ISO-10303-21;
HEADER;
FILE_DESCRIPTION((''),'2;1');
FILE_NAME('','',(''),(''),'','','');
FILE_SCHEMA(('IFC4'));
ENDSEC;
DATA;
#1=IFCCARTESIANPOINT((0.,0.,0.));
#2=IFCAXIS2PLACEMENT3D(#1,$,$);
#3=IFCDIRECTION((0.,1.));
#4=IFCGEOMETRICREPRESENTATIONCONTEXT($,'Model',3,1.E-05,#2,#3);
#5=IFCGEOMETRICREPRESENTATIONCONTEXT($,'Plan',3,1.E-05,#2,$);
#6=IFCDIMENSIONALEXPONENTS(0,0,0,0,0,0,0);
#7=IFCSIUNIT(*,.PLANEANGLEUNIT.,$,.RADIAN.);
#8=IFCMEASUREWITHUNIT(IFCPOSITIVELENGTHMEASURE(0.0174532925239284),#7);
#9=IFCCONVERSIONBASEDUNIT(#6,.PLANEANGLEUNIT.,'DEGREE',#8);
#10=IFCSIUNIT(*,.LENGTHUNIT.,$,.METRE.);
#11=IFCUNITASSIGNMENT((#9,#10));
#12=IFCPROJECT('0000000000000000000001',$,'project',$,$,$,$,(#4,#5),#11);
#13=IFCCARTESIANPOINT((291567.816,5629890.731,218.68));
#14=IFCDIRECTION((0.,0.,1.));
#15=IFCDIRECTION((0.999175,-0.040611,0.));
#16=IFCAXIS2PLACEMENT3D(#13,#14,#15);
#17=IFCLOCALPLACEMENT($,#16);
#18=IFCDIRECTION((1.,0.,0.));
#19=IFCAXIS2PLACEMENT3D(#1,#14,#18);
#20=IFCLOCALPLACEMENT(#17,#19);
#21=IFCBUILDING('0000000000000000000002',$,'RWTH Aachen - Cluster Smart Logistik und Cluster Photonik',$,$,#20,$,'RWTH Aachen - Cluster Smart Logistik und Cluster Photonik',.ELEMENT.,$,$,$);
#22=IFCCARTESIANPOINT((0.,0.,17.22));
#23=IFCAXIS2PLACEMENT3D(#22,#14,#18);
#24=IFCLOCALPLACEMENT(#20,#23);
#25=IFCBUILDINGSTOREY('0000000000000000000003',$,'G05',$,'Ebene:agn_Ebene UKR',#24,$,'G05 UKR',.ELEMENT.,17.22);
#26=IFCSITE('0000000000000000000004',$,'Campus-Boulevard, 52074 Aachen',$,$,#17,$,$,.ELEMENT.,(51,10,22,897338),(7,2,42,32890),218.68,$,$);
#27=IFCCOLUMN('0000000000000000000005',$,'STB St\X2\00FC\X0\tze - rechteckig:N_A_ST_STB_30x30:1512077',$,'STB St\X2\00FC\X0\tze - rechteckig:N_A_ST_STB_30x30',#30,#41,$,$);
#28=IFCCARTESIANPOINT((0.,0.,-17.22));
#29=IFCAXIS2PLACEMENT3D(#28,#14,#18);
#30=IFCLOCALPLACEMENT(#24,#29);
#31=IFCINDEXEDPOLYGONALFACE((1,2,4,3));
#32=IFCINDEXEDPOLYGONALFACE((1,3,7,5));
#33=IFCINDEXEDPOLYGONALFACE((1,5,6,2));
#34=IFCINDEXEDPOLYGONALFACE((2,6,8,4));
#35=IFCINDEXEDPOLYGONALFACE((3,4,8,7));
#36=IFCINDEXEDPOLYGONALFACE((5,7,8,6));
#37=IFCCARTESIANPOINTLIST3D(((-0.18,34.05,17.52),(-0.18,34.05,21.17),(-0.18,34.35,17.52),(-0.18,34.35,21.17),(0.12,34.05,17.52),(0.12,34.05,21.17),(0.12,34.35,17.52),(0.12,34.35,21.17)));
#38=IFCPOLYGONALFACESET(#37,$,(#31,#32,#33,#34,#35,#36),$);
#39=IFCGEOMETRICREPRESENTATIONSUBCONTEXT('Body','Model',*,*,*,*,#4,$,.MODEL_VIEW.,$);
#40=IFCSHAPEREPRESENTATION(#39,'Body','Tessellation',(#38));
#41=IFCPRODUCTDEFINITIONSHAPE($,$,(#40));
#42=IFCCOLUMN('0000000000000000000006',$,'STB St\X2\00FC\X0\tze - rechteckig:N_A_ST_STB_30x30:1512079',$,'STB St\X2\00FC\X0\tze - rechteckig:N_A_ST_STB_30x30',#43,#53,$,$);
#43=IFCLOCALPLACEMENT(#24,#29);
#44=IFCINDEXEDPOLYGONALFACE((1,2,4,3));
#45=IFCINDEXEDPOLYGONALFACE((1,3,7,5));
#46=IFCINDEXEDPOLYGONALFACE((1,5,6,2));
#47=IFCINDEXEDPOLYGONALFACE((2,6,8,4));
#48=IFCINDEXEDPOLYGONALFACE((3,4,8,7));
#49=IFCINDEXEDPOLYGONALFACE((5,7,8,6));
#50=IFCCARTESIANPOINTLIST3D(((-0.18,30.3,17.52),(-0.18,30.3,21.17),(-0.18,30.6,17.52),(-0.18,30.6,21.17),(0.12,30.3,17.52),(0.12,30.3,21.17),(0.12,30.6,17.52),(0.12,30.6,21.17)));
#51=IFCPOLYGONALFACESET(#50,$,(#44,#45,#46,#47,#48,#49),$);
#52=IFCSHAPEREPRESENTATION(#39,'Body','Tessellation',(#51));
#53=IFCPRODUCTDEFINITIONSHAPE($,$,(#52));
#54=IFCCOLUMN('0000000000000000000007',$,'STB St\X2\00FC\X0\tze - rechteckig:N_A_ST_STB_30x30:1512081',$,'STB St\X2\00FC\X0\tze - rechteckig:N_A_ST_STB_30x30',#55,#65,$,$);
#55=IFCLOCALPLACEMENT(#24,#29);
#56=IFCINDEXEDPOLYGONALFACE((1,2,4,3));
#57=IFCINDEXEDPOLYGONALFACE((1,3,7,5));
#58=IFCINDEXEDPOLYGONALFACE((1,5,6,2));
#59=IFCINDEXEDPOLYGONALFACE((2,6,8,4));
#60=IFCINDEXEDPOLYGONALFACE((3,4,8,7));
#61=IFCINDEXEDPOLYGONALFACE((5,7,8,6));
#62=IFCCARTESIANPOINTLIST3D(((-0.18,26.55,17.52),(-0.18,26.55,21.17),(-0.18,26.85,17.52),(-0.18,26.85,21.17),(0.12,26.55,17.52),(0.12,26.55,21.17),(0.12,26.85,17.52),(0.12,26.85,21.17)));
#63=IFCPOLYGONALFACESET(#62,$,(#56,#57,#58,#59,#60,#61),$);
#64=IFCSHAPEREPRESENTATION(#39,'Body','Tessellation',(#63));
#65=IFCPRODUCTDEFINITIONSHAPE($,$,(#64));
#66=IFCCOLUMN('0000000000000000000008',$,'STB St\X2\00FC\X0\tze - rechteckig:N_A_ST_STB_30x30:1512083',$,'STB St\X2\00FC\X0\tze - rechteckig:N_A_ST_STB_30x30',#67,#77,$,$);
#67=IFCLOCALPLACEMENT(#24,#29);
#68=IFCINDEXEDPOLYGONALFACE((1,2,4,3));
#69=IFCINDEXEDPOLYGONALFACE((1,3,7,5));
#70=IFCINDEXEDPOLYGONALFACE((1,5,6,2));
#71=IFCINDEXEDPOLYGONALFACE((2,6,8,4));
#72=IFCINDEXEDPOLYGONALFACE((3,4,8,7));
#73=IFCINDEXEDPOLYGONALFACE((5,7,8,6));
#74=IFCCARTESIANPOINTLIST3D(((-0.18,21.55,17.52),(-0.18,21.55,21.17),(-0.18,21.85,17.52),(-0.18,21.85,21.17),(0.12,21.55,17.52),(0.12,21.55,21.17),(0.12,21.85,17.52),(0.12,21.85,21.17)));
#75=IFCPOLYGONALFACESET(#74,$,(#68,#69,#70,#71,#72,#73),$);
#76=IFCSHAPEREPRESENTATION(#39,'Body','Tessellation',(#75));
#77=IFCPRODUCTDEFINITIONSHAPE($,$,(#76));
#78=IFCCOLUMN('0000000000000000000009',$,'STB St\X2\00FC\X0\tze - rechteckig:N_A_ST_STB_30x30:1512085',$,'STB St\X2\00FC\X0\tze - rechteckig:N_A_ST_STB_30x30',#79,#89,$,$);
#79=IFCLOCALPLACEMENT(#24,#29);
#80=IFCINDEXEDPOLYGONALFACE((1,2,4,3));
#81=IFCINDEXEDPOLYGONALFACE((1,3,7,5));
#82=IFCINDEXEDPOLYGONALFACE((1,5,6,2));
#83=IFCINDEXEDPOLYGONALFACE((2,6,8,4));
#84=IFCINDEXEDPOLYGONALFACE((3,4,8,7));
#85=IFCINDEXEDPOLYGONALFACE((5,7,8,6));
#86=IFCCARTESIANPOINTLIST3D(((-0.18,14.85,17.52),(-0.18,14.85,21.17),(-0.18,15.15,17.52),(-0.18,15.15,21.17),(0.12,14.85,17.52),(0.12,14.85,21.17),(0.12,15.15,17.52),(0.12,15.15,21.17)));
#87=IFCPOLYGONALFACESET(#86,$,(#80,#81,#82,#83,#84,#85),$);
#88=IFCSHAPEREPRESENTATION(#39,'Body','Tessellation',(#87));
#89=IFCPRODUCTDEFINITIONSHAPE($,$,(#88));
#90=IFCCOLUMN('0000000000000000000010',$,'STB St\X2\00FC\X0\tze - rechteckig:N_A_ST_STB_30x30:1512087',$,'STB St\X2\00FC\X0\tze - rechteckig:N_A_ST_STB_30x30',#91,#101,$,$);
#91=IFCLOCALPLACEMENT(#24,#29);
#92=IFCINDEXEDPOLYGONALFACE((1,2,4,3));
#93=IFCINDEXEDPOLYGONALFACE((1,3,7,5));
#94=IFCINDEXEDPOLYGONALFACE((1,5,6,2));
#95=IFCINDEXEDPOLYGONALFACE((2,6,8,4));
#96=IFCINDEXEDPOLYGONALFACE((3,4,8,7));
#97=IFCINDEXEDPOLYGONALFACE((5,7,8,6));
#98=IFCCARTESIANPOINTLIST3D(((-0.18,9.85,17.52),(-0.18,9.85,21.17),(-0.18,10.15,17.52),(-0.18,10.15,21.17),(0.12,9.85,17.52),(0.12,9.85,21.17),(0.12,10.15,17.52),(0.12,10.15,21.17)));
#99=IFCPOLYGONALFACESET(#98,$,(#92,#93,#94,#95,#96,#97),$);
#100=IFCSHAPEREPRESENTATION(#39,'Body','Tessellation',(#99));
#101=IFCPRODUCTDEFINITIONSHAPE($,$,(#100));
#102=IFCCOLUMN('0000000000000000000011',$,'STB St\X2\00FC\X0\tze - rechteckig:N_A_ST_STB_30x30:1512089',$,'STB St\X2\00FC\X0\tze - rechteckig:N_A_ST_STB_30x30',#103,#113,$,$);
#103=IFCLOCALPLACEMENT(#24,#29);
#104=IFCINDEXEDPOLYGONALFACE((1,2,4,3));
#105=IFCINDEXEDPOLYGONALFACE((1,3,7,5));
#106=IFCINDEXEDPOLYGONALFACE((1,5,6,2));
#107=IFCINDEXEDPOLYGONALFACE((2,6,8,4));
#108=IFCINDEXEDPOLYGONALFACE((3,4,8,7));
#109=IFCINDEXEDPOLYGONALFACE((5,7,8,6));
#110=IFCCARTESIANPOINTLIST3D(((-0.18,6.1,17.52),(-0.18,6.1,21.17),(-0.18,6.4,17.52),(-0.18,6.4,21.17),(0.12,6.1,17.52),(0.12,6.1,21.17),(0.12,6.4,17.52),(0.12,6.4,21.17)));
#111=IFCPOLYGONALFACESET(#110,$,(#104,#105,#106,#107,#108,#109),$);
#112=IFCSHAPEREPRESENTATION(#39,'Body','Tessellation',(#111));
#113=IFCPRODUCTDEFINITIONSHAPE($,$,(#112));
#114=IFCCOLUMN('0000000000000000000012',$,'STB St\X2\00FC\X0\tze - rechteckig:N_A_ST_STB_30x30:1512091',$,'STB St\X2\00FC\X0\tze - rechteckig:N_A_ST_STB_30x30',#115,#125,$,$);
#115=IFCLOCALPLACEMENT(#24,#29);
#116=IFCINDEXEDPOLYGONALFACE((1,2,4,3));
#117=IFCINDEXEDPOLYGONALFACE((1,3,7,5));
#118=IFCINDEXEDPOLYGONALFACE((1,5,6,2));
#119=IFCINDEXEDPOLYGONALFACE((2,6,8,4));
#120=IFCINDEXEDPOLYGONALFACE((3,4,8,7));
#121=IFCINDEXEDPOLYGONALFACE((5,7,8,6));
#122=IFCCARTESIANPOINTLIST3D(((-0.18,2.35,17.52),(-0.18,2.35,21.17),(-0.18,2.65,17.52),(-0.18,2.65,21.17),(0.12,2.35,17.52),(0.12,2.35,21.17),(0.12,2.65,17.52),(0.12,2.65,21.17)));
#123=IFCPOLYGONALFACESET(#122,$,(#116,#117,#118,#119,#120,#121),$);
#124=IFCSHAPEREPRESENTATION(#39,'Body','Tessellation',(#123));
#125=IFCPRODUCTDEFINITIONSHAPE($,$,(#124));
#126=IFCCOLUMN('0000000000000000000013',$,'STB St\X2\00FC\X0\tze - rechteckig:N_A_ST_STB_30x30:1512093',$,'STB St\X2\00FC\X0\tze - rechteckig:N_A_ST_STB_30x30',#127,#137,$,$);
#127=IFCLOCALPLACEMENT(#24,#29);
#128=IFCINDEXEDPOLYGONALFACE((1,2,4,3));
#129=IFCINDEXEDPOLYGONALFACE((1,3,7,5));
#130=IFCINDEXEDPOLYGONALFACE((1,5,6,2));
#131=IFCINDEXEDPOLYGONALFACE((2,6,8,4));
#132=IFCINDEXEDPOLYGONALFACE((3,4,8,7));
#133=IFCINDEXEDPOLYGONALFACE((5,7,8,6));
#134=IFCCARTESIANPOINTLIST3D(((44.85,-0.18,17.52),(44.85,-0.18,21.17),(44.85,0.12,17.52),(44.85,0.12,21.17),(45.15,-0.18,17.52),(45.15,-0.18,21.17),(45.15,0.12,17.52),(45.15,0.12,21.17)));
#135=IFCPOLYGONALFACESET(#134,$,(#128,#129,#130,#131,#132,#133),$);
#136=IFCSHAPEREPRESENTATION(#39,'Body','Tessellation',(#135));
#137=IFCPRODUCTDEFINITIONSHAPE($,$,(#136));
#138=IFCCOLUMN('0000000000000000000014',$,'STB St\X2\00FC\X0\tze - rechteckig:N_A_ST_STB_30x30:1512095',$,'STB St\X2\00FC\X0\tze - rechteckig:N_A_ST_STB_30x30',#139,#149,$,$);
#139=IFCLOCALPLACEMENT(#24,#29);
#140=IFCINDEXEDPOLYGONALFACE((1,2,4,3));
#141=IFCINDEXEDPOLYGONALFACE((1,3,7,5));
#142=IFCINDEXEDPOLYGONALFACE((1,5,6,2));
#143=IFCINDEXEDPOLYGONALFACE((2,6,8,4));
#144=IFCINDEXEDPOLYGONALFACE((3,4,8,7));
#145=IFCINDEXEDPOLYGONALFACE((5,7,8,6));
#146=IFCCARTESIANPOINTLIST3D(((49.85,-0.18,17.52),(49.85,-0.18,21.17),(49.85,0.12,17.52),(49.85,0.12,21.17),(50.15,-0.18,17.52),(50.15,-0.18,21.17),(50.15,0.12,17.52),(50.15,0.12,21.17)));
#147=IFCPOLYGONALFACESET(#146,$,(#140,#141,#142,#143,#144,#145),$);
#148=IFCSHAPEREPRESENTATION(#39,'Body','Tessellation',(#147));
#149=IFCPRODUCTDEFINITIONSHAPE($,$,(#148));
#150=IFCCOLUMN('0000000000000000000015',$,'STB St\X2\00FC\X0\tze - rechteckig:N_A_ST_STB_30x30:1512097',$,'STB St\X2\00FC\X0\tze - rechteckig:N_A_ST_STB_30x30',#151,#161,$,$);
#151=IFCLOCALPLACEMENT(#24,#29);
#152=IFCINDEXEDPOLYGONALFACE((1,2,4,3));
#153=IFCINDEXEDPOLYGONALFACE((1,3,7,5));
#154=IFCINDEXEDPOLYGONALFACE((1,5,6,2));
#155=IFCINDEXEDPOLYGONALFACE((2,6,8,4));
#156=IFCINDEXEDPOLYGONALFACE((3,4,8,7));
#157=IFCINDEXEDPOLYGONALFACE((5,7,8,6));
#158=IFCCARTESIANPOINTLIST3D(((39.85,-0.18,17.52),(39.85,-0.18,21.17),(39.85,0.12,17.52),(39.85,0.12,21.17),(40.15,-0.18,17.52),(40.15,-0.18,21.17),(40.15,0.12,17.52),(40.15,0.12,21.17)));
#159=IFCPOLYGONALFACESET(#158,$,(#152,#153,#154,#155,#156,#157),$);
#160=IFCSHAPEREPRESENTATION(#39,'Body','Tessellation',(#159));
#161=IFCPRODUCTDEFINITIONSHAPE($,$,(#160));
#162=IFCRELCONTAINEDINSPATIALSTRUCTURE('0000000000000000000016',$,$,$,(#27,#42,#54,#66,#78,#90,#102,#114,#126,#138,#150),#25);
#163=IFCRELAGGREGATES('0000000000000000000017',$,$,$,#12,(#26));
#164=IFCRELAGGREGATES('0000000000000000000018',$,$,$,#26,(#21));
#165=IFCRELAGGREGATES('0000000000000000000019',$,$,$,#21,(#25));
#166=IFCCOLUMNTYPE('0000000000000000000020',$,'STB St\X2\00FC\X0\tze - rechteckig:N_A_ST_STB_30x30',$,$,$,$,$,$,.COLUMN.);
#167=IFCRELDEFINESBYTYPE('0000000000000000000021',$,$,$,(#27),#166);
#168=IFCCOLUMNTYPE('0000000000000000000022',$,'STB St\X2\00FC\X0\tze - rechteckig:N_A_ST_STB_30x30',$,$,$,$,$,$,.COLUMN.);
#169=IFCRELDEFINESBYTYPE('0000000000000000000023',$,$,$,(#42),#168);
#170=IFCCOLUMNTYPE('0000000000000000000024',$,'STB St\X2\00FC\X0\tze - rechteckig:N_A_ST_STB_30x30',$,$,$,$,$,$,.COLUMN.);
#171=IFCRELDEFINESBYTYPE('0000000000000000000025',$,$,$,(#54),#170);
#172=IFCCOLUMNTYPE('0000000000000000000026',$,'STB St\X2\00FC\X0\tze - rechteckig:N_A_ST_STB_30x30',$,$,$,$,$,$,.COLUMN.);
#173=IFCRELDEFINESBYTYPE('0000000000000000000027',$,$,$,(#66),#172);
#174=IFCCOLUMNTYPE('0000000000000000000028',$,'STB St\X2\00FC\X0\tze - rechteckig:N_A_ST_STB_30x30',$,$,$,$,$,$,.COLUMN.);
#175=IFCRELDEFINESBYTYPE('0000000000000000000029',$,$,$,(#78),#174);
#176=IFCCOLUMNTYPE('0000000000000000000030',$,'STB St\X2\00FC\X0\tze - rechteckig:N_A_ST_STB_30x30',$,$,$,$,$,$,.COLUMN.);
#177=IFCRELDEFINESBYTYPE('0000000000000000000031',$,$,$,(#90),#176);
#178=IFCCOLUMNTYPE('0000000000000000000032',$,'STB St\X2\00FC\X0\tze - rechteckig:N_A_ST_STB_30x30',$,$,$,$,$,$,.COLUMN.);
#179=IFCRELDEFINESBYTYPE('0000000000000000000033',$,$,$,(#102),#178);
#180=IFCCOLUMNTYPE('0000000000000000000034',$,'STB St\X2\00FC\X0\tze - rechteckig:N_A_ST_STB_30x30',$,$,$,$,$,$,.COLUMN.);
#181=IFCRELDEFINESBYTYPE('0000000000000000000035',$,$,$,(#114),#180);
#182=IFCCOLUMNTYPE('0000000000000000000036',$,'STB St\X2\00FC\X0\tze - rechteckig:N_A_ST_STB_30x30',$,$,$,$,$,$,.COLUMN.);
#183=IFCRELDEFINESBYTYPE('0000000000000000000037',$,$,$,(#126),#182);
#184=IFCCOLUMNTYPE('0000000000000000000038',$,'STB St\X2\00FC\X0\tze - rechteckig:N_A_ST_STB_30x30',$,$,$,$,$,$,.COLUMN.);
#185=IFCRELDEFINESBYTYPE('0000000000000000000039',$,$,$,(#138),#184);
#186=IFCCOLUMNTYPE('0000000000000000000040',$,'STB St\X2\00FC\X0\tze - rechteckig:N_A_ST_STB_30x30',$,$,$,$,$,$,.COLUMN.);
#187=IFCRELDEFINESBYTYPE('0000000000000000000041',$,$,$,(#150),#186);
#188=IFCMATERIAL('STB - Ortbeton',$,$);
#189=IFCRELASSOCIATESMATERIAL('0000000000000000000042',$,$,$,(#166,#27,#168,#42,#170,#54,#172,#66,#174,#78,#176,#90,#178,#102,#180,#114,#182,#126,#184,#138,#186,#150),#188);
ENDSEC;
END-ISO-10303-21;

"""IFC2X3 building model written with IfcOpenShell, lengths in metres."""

from ifc_helpers import new_model, entity, si_unit, converted_unit, direction, frame, origin, origin_with_axes, origin_2d_with_axis, place, context, subcontext, project, spatial, rectangle, extrude, source, transform, mapped, material, type_object, element, save


model = new_model("IFC2X3")

# Units and contexts
model_context = context("Model", 3, precision=1e-05, world=origin(), true_north=direction((0.0, 1.0)))
plan_context = context("Plan", 3, precision=1e-05, world=origin())
body_context = subcontext(model_context, "Body", "Model", "MODEL_VIEW")
ifc_project = project(units=[converted_unit("PLANEANGLEUNIT", "DEGREE", entity("IfcPositiveLengthMeasure", 0.0174532925239284), si_unit("PLANEANGLEUNIT", "RADIAN"), dimensions=[0, 0, 0, 0, 0, 0, 0]), si_unit("LENGTHUNIT", "METRE")], contexts=[model_context, plan_context])

# Site, building, storey
site_placement = place(None, frame((291567.816, 5629890.731, 218.68), z_axis=(0.0, 0.0, 1.0), x_axis=(0.999175, -0.040611, 0.0)))
site = spatial("IfcSite", under=ifc_project, at=site_placement, Name="Campus-Boulevard, 52074 Aachen", CompositionType="ELEMENT", RefLatitude=(51, 10, 22, 897338), RefLongitude=(7, 2, 42, 32890), RefElevation=218.68)
building_placement = place(site_placement, origin_with_axes())
building = spatial("IfcBuilding", under=site, at=building_placement, Name="RWTH Aachen - Cluster Smart Logistik und Cluster Photonik", LongName="RWTH Aachen - Cluster Smart Logistik und Cluster Photonik", CompositionType="ELEMENT")
storey_placement = place(building_placement, frame((0.0, 0.0, 17.22), z_axis=(0.0, 0.0, 1.0), x_axis=(1.0, 0.0, 0.0)))
storey = spatial("IfcBuildingStorey", under=building, at=storey_placement, Name="G05", ObjectType="Ebene:agn_Ebene UKR", LongName="G05 UKR", CompositionType="ELEMENT", Elevation=17.22)

# Columns
ifc_material = material(Name="STB - Ortbeton")
column_type_1 = type_object("IfcColumnType", Name="STB Stütze - rechteckig:N_A_ST_STB_30x30", PredefinedType="COLUMN", material=ifc_material)
shared_shape_1 = source(origin(), body_context, "Body", "SweptSolid", [
    extrude(rectangle(XDim=0.3, YDim=0.3, at=origin_2d_with_axis()), frame((-0.03, 34.2, 17.52), z_axis=(0.0, 0.0, 1.0), x_axis=(0.0, -1.0, 0.0)), (0.0, 0.0, 1.0), 3.65),
])
column_1_placement = place(storey_placement, frame((0.0, 0.0, -17.22), z_axis=(0.0, 0.0, 1.0), x_axis=(1.0, 0.0, 0.0)))
element("IfcColumn", 1, at=column_1_placement, inside=storey, type_object=column_type_1, material=ifc_material, Name="STB Stütze - rechteckig:N_A_ST_STB_30x30:1512077", ObjectType="STB Stütze - rechteckig:N_A_ST_STB_30x30", context=body_context, shape_type="MappedRepresentation", body=[
    mapped(shared_shape_1, transform((0.0, 0.0, 0.0), scale=1.0)),
])
column_type_2 = type_object("IfcColumnType", Name="STB Stütze - rechteckig:N_A_ST_STB_30x30", PredefinedType="COLUMN", material=ifc_material)
shared_shape_2 = source(origin(), body_context, "Body", "SweptSolid", [
    extrude(rectangle(XDim=0.3, YDim=0.3, at=origin_2d_with_axis()), frame((-0.03, 30.45, 17.52), z_axis=(0.0, 0.0, 1.0), x_axis=(0.0, -1.0, 0.0)), (0.0, 0.0, 1.0), 3.65),
])
column_2_placement = place(storey_placement, frame((0.0, 0.0, -17.22), z_axis=(0.0, 0.0, 1.0), x_axis=(1.0, 0.0, 0.0)))
element("IfcColumn", 2, at=column_2_placement, inside=storey, type_object=column_type_2, material=ifc_material, Name="STB Stütze - rechteckig:N_A_ST_STB_30x30:1512079", ObjectType="STB Stütze - rechteckig:N_A_ST_STB_30x30", context=body_context, shape_type="MappedRepresentation", body=[
    mapped(shared_shape_2, transform((0.0, 0.0, 0.0), scale=1.0)),
])
column_type_3 = type_object("IfcColumnType", Name="STB Stütze - rechteckig:N_A_ST_STB_30x30", PredefinedType="COLUMN", material=ifc_material)
shared_shape_3 = source(origin(), body_context, "Body", "SweptSolid", [
    extrude(rectangle(XDim=0.3, YDim=0.3, at=origin_2d_with_axis()), frame((-0.03, 26.7, 17.52), z_axis=(0.0, 0.0, 1.0), x_axis=(0.0, -1.0, 0.0)), (0.0, 0.0, 1.0), 3.65),
])
column_3_placement = place(storey_placement, frame((0.0, 0.0, -17.22), z_axis=(0.0, 0.0, 1.0), x_axis=(1.0, 0.0, 0.0)))
element("IfcColumn", 3, at=column_3_placement, inside=storey, type_object=column_type_3, material=ifc_material, Name="STB Stütze - rechteckig:N_A_ST_STB_30x30:1512081", ObjectType="STB Stütze - rechteckig:N_A_ST_STB_30x30", context=body_context, shape_type="MappedRepresentation", body=[
    mapped(shared_shape_3, transform((0.0, 0.0, 0.0), scale=1.0)),
])
column_type_4 = type_object("IfcColumnType", Name="STB Stütze - rechteckig:N_A_ST_STB_30x30", PredefinedType="COLUMN", material=ifc_material)
shared_shape_4 = source(origin(), body_context, "Body", "SweptSolid", [
    extrude(rectangle(XDim=0.3, YDim=0.3, at=origin_2d_with_axis()), frame((-0.03, 21.7, 17.52), z_axis=(0.0, 0.0, 1.0), x_axis=(0.0, -1.0, 0.0)), (0.0, 0.0, 1.0), 3.65),
])
column_4_placement = place(storey_placement, frame((0.0, 0.0, -17.22), z_axis=(0.0, 0.0, 1.0), x_axis=(1.0, 0.0, 0.0)))
element("IfcColumn", 4, at=column_4_placement, inside=storey, type_object=column_type_4, material=ifc_material, Name="STB Stütze - rechteckig:N_A_ST_STB_30x30:1512083", ObjectType="STB Stütze - rechteckig:N_A_ST_STB_30x30", context=body_context, shape_type="MappedRepresentation", body=[
    mapped(shared_shape_4, transform((0.0, 0.0, 0.0), scale=1.0)),
])
column_type_5 = type_object("IfcColumnType", Name="STB Stütze - rechteckig:N_A_ST_STB_30x30", PredefinedType="COLUMN", material=ifc_material)
shared_shape_5 = source(origin(), body_context, "Body", "SweptSolid", [
    extrude(rectangle(XDim=0.3, YDim=0.3, at=origin_2d_with_axis()), frame((-0.03, 15.0, 17.52), z_axis=(0.0, 0.0, 1.0), x_axis=(0.0, -1.0, 0.0)), (0.0, 0.0, 1.0), 3.65),
])
column_5_placement = place(storey_placement, frame((0.0, 0.0, -17.22), z_axis=(0.0, 0.0, 1.0), x_axis=(1.0, 0.0, 0.0)))
element("IfcColumn", 5, at=column_5_placement, inside=storey, type_object=column_type_5, material=ifc_material, Name="STB Stütze - rechteckig:N_A_ST_STB_30x30:1512085", ObjectType="STB Stütze - rechteckig:N_A_ST_STB_30x30", context=body_context, shape_type="MappedRepresentation", body=[
    mapped(shared_shape_5, transform((0.0, 0.0, 0.0), scale=1.0)),
])
column_type_6 = type_object("IfcColumnType", Name="STB Stütze - rechteckig:N_A_ST_STB_30x30", PredefinedType="COLUMN", material=ifc_material)
shared_shape_6 = source(origin(), body_context, "Body", "SweptSolid", [
    extrude(rectangle(XDim=0.3, YDim=0.3, at=origin_2d_with_axis()), frame((-0.03, 10.0, 17.52), z_axis=(0.0, 0.0, 1.0), x_axis=(0.0, -1.0, 0.0)), (0.0, 0.0, 1.0), 3.65),
])
column_6_placement = place(storey_placement, frame((0.0, 0.0, -17.22), z_axis=(0.0, 0.0, 1.0), x_axis=(1.0, 0.0, 0.0)))
element("IfcColumn", 6, at=column_6_placement, inside=storey, type_object=column_type_6, material=ifc_material, Name="STB Stütze - rechteckig:N_A_ST_STB_30x30:1512087", ObjectType="STB Stütze - rechteckig:N_A_ST_STB_30x30", context=body_context, shape_type="MappedRepresentation", body=[
    mapped(shared_shape_6, transform((0.0, 0.0, 0.0), scale=1.0)),
])
column_type_7 = type_object("IfcColumnType", Name="STB Stütze - rechteckig:N_A_ST_STB_30x30", PredefinedType="COLUMN", material=ifc_material)
shared_shape_7 = source(origin(), body_context, "Body", "SweptSolid", [
    extrude(rectangle(XDim=0.3, YDim=0.3, at=origin_2d_with_axis()), frame((-0.03, 6.25, 17.52), z_axis=(0.0, 0.0, 1.0), x_axis=(0.0, -1.0, 0.0)), (0.0, 0.0, 1.0), 3.65),
])
column_7_placement = place(storey_placement, frame((0.0, 0.0, -17.22), z_axis=(0.0, 0.0, 1.0), x_axis=(1.0, 0.0, 0.0)))
element("IfcColumn", 7, at=column_7_placement, inside=storey, type_object=column_type_7, material=ifc_material, Name="STB Stütze - rechteckig:N_A_ST_STB_30x30:1512089", ObjectType="STB Stütze - rechteckig:N_A_ST_STB_30x30", context=body_context, shape_type="MappedRepresentation", body=[
    mapped(shared_shape_7, transform((0.0, 0.0, 0.0), scale=1.0)),
])
column_type_8 = type_object("IfcColumnType", Name="STB Stütze - rechteckig:N_A_ST_STB_30x30", PredefinedType="COLUMN", material=ifc_material)
shared_shape_8 = source(origin(), body_context, "Body", "SweptSolid", [
    extrude(rectangle(XDim=0.3, YDim=0.3, at=origin_2d_with_axis()), frame((-0.03, 2.5, 17.52), z_axis=(0.0, 0.0, 1.0), x_axis=(0.0, -1.0, 0.0)), (0.0, 0.0, 1.0), 3.65),
])
column_8_placement = place(storey_placement, frame((0.0, 0.0, -17.22), z_axis=(0.0, 0.0, 1.0), x_axis=(1.0, 0.0, 0.0)))
element("IfcColumn", 8, at=column_8_placement, inside=storey, type_object=column_type_8, material=ifc_material, Name="STB Stütze - rechteckig:N_A_ST_STB_30x30:1512091", ObjectType="STB Stütze - rechteckig:N_A_ST_STB_30x30", context=body_context, shape_type="MappedRepresentation", body=[
    mapped(shared_shape_8, transform((0.0, 0.0, 0.0), scale=1.0)),
])
column_type_9 = type_object("IfcColumnType", Name="STB Stütze - rechteckig:N_A_ST_STB_30x30", PredefinedType="COLUMN", material=ifc_material)
shared_shape_9 = source(origin(), body_context, "Body", "SweptSolid", [
    extrude(rectangle(XDim=0.3, YDim=0.3, at=origin_2d_with_axis()), frame((45.0, -0.03, 17.52), z_axis=(0.0, 0.0, 1.0), x_axis=(0.0, -1.0, 0.0)), (0.0, 0.0, 1.0), 3.65),
])
column_9_placement = place(storey_placement, frame((0.0, 0.0, -17.22), z_axis=(0.0, 0.0, 1.0), x_axis=(1.0, 0.0, 0.0)))
element("IfcColumn", 9, at=column_9_placement, inside=storey, type_object=column_type_9, material=ifc_material, Name="STB Stütze - rechteckig:N_A_ST_STB_30x30:1512093", ObjectType="STB Stütze - rechteckig:N_A_ST_STB_30x30", context=body_context, shape_type="MappedRepresentation", body=[
    mapped(shared_shape_9, transform((0.0, 0.0, 0.0), scale=1.0)),
])
column_type_10 = type_object("IfcColumnType", Name="STB Stütze - rechteckig:N_A_ST_STB_30x30", PredefinedType="COLUMN", material=ifc_material)
shared_shape_10 = source(origin(), body_context, "Body", "SweptSolid", [
    extrude(rectangle(XDim=0.3, YDim=0.3, at=origin_2d_with_axis()), frame((50.0, -0.03, 17.52), z_axis=(0.0, 0.0, 1.0), x_axis=(0.0, -1.0, 0.0)), (0.0, 0.0, 1.0), 3.65),
])
column_10_placement = place(storey_placement, frame((0.0, 0.0, -17.22), z_axis=(0.0, 0.0, 1.0), x_axis=(1.0, 0.0, 0.0)))
element("IfcColumn", 10, at=column_10_placement, inside=storey, type_object=column_type_10, material=ifc_material, Name="STB Stütze - rechteckig:N_A_ST_STB_30x30:1512095", ObjectType="STB Stütze - rechteckig:N_A_ST_STB_30x30", context=body_context, shape_type="MappedRepresentation", body=[
    mapped(shared_shape_10, transform((0.0, 0.0, 0.0), scale=1.0)),
])
column_type_11 = type_object("IfcColumnType", Name="STB Stütze - rechteckig:N_A_ST_STB_30x30", PredefinedType="COLUMN", material=ifc_material)
shared_shape_11 = source(origin(), body_context, "Body", "SweptSolid", [
    extrude(rectangle(XDim=0.3, YDim=0.3, at=origin_2d_with_axis()), frame((40.0, -0.03, 17.52), z_axis=(0.0, 0.0, 1.0), x_axis=(0.0, -1.0, 0.0)), (0.0, 0.0, 1.0), 3.65),
])
column_11_placement = place(storey_placement, frame((0.0, 0.0, -17.22), z_axis=(0.0, 0.0, 1.0), x_axis=(1.0, 0.0, 0.0)))
element("IfcColumn", 11, at=column_11_placement, inside=storey, type_object=column_type_11, material=ifc_material, Name="STB Stütze - rechteckig:N_A_ST_STB_30x30:1512097", ObjectType="STB Stütze - rechteckig:N_A_ST_STB_30x30", context=body_context, shape_type="MappedRepresentation", body=[
    mapped(shared_shape_11, transform((0.0, 0.0, 0.0), scale=1.0)),
])

save(model, "model.ifc")
